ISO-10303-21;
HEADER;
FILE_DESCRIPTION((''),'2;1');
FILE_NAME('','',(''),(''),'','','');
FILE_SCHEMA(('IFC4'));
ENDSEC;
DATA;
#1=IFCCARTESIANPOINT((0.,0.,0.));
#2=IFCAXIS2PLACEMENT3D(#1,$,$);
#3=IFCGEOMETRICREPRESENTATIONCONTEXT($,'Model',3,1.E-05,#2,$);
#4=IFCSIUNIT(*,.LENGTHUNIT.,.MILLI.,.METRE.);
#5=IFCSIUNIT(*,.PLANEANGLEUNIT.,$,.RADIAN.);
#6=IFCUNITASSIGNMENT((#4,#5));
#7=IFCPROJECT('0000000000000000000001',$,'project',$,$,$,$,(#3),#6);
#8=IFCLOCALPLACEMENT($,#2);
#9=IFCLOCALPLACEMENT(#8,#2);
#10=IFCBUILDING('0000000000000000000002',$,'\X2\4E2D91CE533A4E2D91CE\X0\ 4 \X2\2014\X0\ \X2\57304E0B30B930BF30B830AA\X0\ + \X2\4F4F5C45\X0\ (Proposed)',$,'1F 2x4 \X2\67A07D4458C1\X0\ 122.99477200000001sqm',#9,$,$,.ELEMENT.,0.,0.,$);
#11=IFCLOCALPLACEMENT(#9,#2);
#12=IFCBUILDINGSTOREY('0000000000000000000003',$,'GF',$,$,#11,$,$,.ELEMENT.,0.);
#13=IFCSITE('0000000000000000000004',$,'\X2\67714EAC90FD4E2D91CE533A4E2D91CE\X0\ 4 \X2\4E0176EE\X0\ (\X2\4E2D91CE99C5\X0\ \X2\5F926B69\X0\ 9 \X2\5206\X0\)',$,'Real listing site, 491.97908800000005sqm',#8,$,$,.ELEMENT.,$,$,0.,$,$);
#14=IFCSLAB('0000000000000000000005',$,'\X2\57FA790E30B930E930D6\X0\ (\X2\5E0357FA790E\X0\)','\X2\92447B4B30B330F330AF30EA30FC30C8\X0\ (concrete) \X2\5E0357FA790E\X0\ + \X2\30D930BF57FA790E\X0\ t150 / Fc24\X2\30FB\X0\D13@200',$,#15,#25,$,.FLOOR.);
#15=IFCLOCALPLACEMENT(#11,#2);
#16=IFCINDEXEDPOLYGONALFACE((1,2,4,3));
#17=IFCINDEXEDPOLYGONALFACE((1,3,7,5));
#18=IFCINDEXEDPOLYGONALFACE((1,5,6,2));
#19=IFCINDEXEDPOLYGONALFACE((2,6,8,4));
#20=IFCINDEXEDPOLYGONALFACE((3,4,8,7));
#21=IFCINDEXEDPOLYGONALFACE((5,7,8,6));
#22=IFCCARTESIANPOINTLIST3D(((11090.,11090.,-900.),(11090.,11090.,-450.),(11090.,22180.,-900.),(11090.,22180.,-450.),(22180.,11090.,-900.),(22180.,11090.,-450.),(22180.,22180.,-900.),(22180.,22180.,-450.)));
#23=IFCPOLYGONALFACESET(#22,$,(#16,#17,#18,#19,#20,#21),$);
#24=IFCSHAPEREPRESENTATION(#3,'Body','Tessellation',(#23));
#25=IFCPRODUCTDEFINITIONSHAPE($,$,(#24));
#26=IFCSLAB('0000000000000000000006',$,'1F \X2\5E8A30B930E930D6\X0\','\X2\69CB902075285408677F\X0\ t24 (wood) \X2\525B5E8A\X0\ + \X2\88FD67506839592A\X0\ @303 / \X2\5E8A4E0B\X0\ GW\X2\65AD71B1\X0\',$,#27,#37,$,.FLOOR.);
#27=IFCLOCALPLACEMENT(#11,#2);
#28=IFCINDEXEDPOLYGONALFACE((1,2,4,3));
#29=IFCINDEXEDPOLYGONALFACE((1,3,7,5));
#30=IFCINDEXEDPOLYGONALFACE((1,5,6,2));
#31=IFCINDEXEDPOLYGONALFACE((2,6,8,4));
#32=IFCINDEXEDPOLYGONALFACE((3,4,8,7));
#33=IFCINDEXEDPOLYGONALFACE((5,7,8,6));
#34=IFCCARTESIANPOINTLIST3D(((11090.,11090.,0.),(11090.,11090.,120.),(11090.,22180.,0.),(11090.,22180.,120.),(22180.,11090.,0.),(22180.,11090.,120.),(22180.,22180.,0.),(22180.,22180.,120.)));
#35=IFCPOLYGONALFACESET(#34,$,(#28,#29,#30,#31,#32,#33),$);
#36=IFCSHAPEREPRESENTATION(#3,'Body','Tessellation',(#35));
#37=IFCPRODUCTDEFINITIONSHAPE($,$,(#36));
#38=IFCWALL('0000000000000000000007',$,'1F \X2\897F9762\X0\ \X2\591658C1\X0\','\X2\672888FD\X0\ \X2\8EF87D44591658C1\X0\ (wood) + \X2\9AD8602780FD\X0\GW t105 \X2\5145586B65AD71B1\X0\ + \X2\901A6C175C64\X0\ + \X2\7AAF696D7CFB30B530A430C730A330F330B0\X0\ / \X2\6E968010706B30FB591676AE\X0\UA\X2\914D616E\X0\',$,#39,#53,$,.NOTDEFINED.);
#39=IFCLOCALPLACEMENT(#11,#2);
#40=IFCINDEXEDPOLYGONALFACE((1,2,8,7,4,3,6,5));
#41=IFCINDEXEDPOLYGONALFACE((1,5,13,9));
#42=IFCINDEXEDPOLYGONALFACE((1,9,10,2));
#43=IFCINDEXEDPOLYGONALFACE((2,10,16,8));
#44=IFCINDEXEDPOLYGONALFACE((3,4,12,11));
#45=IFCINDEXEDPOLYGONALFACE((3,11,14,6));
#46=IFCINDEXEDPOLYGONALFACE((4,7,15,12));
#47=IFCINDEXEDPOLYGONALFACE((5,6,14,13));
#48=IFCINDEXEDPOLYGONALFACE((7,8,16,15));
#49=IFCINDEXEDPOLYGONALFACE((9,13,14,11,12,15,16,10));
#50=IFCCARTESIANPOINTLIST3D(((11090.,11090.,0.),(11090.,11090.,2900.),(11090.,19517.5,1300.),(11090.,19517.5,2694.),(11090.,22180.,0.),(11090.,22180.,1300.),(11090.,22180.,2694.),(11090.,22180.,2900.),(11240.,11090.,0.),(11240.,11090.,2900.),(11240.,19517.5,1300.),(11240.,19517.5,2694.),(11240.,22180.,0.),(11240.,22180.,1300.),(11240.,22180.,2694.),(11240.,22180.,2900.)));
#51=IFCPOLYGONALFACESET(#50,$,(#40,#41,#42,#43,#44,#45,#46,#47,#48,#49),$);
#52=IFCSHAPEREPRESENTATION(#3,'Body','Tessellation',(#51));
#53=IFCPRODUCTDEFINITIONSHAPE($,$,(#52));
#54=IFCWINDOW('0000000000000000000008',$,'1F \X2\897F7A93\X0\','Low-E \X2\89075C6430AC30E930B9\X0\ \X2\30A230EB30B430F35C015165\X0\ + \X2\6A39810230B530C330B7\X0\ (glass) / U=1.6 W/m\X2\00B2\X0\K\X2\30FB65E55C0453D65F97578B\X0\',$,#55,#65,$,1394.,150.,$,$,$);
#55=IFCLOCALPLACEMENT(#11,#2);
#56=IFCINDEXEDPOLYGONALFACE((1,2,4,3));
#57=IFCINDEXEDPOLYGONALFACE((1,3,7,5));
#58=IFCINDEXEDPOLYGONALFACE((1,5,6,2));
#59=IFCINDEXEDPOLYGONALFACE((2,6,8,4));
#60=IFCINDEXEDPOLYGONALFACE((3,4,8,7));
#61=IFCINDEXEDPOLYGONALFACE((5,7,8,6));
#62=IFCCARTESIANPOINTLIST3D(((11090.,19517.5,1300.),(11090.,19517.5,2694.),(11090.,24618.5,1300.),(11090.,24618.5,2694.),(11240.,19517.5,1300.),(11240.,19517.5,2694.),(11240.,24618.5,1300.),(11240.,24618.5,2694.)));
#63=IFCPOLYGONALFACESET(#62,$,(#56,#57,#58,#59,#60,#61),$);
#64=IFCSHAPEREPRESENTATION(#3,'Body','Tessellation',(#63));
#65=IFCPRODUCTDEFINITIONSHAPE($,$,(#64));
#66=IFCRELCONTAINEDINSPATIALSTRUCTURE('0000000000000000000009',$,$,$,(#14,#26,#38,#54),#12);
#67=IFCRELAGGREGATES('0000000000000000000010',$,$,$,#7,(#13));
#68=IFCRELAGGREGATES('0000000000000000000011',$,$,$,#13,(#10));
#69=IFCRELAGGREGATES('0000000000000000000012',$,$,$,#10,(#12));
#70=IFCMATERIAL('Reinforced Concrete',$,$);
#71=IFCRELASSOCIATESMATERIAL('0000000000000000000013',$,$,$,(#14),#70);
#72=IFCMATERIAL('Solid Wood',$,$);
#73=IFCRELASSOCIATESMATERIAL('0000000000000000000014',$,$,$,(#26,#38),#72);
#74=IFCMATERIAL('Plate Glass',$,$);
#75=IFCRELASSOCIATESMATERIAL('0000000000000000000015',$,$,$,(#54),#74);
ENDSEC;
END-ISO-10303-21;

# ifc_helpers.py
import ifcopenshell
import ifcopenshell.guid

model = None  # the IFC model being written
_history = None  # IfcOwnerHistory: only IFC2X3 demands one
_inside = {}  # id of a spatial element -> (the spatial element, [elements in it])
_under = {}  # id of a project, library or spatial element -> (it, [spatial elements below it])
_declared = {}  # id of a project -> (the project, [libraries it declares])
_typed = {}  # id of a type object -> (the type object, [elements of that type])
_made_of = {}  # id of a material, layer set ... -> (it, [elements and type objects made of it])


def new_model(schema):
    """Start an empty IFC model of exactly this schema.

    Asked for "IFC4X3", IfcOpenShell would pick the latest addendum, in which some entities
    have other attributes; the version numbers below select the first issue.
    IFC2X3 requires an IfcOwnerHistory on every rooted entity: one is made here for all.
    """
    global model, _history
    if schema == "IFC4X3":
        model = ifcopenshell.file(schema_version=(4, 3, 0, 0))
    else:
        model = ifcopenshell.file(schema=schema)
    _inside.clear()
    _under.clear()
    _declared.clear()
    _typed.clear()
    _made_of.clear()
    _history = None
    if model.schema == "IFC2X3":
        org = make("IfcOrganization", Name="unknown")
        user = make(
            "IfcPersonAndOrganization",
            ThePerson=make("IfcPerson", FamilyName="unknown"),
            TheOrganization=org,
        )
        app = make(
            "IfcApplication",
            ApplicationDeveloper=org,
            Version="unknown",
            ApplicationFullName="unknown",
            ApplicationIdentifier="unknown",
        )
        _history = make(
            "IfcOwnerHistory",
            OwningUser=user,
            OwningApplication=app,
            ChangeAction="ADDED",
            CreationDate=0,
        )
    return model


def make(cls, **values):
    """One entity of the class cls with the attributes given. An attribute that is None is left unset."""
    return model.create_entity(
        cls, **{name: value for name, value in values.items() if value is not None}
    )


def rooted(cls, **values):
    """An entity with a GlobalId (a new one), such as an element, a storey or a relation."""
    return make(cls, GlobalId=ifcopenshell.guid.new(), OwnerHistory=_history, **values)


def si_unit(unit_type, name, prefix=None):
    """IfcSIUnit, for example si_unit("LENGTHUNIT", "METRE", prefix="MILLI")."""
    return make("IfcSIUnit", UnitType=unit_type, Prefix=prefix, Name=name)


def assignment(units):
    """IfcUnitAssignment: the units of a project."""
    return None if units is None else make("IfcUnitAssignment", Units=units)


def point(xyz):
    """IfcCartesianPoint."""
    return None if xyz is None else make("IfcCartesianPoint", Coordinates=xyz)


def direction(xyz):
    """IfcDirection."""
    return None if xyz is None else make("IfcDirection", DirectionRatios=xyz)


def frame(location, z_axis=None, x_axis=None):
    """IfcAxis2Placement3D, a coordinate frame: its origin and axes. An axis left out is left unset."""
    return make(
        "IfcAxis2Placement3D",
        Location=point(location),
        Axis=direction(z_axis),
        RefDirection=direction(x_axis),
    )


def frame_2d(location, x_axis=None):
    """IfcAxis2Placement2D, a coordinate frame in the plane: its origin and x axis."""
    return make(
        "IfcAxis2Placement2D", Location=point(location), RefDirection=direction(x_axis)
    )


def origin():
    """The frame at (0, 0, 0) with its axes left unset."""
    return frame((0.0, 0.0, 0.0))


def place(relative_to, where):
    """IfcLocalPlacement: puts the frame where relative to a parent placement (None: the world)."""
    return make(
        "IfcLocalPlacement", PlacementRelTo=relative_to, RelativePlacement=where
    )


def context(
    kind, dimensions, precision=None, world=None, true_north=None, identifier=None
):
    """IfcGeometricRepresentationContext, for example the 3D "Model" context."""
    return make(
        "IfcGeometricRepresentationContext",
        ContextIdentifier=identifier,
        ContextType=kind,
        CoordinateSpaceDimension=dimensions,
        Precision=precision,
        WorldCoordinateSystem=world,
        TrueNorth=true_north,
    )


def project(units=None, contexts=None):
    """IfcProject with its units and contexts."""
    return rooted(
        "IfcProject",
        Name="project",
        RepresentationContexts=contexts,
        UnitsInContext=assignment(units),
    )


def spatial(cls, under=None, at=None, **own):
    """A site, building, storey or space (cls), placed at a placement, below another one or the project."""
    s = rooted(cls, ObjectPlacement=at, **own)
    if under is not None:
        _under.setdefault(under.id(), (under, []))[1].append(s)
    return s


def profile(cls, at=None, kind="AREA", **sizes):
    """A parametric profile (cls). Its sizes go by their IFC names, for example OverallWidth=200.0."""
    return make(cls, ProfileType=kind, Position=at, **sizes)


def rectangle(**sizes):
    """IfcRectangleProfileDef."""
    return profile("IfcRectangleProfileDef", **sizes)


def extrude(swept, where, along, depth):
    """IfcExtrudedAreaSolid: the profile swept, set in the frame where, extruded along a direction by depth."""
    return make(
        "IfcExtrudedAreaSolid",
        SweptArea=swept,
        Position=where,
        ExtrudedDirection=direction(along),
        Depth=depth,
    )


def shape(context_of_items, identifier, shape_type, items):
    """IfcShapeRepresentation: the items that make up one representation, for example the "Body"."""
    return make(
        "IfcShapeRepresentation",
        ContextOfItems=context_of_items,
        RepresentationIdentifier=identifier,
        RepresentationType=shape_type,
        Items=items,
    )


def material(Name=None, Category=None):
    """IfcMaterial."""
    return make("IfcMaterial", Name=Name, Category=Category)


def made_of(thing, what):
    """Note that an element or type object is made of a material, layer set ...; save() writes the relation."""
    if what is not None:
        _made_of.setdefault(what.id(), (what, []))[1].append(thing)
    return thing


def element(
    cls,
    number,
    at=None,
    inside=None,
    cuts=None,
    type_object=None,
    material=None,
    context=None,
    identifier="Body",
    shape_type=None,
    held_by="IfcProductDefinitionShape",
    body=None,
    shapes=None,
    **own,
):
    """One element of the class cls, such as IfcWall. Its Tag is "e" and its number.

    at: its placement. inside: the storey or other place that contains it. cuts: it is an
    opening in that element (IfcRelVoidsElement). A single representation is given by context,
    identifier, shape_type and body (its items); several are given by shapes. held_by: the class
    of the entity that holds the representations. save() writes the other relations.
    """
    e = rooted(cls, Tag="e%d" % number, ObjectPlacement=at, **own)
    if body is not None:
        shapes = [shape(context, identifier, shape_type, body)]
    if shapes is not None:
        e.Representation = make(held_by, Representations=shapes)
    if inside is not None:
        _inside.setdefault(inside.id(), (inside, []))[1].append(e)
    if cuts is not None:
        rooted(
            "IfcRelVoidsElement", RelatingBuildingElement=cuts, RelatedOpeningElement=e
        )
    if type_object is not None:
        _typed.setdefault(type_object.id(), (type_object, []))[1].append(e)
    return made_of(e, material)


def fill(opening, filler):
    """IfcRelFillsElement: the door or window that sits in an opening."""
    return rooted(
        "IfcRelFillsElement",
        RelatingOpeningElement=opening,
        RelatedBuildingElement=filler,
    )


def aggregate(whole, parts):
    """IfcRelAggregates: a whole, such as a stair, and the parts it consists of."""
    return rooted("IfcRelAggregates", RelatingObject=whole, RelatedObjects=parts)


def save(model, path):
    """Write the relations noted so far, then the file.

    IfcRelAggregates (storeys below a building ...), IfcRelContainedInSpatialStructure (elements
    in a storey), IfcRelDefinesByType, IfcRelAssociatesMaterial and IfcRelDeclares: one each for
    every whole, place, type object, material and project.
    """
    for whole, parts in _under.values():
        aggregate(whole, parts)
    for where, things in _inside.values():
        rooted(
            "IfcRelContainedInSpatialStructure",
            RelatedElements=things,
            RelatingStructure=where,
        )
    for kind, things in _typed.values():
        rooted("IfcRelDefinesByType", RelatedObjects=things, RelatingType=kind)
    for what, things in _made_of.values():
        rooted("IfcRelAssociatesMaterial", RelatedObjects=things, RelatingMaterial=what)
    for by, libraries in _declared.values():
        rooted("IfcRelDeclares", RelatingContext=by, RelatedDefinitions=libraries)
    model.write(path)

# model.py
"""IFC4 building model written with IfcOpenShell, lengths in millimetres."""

from ifc_helpers import new_model, si_unit, frame, frame_2d, origin, place, context, project, spatial, rectangle, extrude, material, element, fill, save


model = new_model("IFC4")

# Units and contexts
model_context = context("Model", 3, precision=1e-05, world=origin())
ifc_project = project(units=[si_unit("LENGTHUNIT", "METRE", prefix="MILLI"), si_unit("PLANEANGLEUNIT", "RADIAN")], contexts=[model_context])

# Site, building, storey
site_placement = place(None, origin())
site = spatial("IfcSite", under=ifc_project, at=site_placement, Name="東京都中野区中野 4 丁目 (中野駅 徒歩 9 分)", ObjectType="Real listing site, 491.97908800000005sqm", CompositionType="ELEMENT", RefElevation=0.0)
building_placement = place(site_placement, origin())
building = spatial("IfcBuilding", under=site, at=building_placement, Name="中野区中野 4 — 地下スタジオ + 住居 (Proposed)", ObjectType="1F 2x4 枠組壁 122.99477200000001sqm", CompositionType="ELEMENT", ElevationOfRefHeight=0.0, ElevationOfTerrain=0.0)
storey_placement = place(building_placement, origin())
storey = spatial("IfcBuildingStorey", under=building, at=storey_placement, Name="GF", CompositionType="ELEMENT", Elevation=0.0)

# Slabs
ifc_material_1 = material(Name="Reinforced Concrete")
slab_1_placement = place(storey_placement, frame((5545.0, 5545.0, -450.0)))
element("IfcSlab", 1, at=slab_1_placement, inside=storey, material=ifc_material_1, Name="基礎スラブ (布基礎)", Description="鉄筋コンクリート (concrete) 布基礎 + ベタ基礎 t150 / Fc24・D13@200", PredefinedType="FLOOR", context=model_context, shape_type="SweptSolid", body=[
    extrude(rectangle(XDim=11090.0, YDim=11090.0, at=frame_2d((5545.0, 5545.0))), frame((5545.0, 5545.0, -450.0)), (0.0, 0.0, 1.0), 450.0),
])
ifc_material_2 = material(Name="Solid Wood")
slab_2_placement = place(storey_placement, frame((5545.0, 5545.0, 0.0)))
element("IfcSlab", 2, at=slab_2_placement, inside=storey, material=ifc_material_2, Name="1F 床スラブ", Description="構造用合板 t24 (wood) 剛床 + 製材根太 @303 / 床下 GW断熱", PredefinedType="FLOOR", context=model_context, shape_type="SweptSolid", body=[
    extrude(rectangle(XDim=11090.0, YDim=11090.0, at=frame_2d((5545.0, 5545.0))), frame((5545.0, 5545.0, 0.0)), (0.0, 0.0, 1.0), 120.0),
])

# Shared definitions
ifc_material_3 = material(Name="Plate Glass")

# Wall, opening, window
wall_1_placement = place(storey_placement, frame((5545.0, 5545.0, 0.0)))
wall_1 = element("IfcWall", 3, at=wall_1_placement, inside=storey, material=ifc_material_2, Name="1F 西面 外壁", Description="木製 軸組外壁 (wood) + 高性能GW t105 充填断熱 + 通気層 + 窯業系サイディング / 準耐火・外皮UA配慮", PredefinedType="NOTDEFINED", context=model_context, shape_type="SweptSolid", body=[
    extrude(rectangle(XDim=150.0, YDim=11090.0, at=frame_2d((75.0, 5545.0))), frame((5545.0, 5545.0, 0.0)), (0.0, 0.0, 1.0), 2900.0),
])
opening_1_placement = place(storey_placement, frame((5545.0, 9759.0, 650.0)))
opening_1 = element("IfcOpeningElement", 4, at=opening_1_placement, cuts=wall_1, PredefinedType="NOTDEFINED", context=model_context, shape_type="SweptSolid", body=[
    extrude(rectangle(XDim=150.0, YDim=5101.0, at=frame_2d((75.0, 2550.0))), frame((5545.0, 9759.0, 650.0)), (0.0, 0.0, 1.0), 1394.0),
])
window_1_placement = place(storey_placement, frame((5545.0, 9759.0, 650.0)))
window_1 = element("IfcWindow", 5, at=window_1_placement, inside=storey, material=ifc_material_3, Name="1F 西窓", Description="Low-E 複層ガラス アルゴン封入 + 樹脂サッシ (glass) / U=1.6 W/m²K・日射取得型", OverallHeight=1394.0, OverallWidth=150.0, context=model_context, shape_type="SweptSolid", body=[
    extrude(rectangle(XDim=150.0, YDim=5101.0, at=frame_2d((75.0, 2550.0))), frame((5545.0, 9759.0, 650.0)), (0.0, 0.0, 1.0), 1394.0),
])
fill(opening_1, window_1)

save(model, "model.ifc")
